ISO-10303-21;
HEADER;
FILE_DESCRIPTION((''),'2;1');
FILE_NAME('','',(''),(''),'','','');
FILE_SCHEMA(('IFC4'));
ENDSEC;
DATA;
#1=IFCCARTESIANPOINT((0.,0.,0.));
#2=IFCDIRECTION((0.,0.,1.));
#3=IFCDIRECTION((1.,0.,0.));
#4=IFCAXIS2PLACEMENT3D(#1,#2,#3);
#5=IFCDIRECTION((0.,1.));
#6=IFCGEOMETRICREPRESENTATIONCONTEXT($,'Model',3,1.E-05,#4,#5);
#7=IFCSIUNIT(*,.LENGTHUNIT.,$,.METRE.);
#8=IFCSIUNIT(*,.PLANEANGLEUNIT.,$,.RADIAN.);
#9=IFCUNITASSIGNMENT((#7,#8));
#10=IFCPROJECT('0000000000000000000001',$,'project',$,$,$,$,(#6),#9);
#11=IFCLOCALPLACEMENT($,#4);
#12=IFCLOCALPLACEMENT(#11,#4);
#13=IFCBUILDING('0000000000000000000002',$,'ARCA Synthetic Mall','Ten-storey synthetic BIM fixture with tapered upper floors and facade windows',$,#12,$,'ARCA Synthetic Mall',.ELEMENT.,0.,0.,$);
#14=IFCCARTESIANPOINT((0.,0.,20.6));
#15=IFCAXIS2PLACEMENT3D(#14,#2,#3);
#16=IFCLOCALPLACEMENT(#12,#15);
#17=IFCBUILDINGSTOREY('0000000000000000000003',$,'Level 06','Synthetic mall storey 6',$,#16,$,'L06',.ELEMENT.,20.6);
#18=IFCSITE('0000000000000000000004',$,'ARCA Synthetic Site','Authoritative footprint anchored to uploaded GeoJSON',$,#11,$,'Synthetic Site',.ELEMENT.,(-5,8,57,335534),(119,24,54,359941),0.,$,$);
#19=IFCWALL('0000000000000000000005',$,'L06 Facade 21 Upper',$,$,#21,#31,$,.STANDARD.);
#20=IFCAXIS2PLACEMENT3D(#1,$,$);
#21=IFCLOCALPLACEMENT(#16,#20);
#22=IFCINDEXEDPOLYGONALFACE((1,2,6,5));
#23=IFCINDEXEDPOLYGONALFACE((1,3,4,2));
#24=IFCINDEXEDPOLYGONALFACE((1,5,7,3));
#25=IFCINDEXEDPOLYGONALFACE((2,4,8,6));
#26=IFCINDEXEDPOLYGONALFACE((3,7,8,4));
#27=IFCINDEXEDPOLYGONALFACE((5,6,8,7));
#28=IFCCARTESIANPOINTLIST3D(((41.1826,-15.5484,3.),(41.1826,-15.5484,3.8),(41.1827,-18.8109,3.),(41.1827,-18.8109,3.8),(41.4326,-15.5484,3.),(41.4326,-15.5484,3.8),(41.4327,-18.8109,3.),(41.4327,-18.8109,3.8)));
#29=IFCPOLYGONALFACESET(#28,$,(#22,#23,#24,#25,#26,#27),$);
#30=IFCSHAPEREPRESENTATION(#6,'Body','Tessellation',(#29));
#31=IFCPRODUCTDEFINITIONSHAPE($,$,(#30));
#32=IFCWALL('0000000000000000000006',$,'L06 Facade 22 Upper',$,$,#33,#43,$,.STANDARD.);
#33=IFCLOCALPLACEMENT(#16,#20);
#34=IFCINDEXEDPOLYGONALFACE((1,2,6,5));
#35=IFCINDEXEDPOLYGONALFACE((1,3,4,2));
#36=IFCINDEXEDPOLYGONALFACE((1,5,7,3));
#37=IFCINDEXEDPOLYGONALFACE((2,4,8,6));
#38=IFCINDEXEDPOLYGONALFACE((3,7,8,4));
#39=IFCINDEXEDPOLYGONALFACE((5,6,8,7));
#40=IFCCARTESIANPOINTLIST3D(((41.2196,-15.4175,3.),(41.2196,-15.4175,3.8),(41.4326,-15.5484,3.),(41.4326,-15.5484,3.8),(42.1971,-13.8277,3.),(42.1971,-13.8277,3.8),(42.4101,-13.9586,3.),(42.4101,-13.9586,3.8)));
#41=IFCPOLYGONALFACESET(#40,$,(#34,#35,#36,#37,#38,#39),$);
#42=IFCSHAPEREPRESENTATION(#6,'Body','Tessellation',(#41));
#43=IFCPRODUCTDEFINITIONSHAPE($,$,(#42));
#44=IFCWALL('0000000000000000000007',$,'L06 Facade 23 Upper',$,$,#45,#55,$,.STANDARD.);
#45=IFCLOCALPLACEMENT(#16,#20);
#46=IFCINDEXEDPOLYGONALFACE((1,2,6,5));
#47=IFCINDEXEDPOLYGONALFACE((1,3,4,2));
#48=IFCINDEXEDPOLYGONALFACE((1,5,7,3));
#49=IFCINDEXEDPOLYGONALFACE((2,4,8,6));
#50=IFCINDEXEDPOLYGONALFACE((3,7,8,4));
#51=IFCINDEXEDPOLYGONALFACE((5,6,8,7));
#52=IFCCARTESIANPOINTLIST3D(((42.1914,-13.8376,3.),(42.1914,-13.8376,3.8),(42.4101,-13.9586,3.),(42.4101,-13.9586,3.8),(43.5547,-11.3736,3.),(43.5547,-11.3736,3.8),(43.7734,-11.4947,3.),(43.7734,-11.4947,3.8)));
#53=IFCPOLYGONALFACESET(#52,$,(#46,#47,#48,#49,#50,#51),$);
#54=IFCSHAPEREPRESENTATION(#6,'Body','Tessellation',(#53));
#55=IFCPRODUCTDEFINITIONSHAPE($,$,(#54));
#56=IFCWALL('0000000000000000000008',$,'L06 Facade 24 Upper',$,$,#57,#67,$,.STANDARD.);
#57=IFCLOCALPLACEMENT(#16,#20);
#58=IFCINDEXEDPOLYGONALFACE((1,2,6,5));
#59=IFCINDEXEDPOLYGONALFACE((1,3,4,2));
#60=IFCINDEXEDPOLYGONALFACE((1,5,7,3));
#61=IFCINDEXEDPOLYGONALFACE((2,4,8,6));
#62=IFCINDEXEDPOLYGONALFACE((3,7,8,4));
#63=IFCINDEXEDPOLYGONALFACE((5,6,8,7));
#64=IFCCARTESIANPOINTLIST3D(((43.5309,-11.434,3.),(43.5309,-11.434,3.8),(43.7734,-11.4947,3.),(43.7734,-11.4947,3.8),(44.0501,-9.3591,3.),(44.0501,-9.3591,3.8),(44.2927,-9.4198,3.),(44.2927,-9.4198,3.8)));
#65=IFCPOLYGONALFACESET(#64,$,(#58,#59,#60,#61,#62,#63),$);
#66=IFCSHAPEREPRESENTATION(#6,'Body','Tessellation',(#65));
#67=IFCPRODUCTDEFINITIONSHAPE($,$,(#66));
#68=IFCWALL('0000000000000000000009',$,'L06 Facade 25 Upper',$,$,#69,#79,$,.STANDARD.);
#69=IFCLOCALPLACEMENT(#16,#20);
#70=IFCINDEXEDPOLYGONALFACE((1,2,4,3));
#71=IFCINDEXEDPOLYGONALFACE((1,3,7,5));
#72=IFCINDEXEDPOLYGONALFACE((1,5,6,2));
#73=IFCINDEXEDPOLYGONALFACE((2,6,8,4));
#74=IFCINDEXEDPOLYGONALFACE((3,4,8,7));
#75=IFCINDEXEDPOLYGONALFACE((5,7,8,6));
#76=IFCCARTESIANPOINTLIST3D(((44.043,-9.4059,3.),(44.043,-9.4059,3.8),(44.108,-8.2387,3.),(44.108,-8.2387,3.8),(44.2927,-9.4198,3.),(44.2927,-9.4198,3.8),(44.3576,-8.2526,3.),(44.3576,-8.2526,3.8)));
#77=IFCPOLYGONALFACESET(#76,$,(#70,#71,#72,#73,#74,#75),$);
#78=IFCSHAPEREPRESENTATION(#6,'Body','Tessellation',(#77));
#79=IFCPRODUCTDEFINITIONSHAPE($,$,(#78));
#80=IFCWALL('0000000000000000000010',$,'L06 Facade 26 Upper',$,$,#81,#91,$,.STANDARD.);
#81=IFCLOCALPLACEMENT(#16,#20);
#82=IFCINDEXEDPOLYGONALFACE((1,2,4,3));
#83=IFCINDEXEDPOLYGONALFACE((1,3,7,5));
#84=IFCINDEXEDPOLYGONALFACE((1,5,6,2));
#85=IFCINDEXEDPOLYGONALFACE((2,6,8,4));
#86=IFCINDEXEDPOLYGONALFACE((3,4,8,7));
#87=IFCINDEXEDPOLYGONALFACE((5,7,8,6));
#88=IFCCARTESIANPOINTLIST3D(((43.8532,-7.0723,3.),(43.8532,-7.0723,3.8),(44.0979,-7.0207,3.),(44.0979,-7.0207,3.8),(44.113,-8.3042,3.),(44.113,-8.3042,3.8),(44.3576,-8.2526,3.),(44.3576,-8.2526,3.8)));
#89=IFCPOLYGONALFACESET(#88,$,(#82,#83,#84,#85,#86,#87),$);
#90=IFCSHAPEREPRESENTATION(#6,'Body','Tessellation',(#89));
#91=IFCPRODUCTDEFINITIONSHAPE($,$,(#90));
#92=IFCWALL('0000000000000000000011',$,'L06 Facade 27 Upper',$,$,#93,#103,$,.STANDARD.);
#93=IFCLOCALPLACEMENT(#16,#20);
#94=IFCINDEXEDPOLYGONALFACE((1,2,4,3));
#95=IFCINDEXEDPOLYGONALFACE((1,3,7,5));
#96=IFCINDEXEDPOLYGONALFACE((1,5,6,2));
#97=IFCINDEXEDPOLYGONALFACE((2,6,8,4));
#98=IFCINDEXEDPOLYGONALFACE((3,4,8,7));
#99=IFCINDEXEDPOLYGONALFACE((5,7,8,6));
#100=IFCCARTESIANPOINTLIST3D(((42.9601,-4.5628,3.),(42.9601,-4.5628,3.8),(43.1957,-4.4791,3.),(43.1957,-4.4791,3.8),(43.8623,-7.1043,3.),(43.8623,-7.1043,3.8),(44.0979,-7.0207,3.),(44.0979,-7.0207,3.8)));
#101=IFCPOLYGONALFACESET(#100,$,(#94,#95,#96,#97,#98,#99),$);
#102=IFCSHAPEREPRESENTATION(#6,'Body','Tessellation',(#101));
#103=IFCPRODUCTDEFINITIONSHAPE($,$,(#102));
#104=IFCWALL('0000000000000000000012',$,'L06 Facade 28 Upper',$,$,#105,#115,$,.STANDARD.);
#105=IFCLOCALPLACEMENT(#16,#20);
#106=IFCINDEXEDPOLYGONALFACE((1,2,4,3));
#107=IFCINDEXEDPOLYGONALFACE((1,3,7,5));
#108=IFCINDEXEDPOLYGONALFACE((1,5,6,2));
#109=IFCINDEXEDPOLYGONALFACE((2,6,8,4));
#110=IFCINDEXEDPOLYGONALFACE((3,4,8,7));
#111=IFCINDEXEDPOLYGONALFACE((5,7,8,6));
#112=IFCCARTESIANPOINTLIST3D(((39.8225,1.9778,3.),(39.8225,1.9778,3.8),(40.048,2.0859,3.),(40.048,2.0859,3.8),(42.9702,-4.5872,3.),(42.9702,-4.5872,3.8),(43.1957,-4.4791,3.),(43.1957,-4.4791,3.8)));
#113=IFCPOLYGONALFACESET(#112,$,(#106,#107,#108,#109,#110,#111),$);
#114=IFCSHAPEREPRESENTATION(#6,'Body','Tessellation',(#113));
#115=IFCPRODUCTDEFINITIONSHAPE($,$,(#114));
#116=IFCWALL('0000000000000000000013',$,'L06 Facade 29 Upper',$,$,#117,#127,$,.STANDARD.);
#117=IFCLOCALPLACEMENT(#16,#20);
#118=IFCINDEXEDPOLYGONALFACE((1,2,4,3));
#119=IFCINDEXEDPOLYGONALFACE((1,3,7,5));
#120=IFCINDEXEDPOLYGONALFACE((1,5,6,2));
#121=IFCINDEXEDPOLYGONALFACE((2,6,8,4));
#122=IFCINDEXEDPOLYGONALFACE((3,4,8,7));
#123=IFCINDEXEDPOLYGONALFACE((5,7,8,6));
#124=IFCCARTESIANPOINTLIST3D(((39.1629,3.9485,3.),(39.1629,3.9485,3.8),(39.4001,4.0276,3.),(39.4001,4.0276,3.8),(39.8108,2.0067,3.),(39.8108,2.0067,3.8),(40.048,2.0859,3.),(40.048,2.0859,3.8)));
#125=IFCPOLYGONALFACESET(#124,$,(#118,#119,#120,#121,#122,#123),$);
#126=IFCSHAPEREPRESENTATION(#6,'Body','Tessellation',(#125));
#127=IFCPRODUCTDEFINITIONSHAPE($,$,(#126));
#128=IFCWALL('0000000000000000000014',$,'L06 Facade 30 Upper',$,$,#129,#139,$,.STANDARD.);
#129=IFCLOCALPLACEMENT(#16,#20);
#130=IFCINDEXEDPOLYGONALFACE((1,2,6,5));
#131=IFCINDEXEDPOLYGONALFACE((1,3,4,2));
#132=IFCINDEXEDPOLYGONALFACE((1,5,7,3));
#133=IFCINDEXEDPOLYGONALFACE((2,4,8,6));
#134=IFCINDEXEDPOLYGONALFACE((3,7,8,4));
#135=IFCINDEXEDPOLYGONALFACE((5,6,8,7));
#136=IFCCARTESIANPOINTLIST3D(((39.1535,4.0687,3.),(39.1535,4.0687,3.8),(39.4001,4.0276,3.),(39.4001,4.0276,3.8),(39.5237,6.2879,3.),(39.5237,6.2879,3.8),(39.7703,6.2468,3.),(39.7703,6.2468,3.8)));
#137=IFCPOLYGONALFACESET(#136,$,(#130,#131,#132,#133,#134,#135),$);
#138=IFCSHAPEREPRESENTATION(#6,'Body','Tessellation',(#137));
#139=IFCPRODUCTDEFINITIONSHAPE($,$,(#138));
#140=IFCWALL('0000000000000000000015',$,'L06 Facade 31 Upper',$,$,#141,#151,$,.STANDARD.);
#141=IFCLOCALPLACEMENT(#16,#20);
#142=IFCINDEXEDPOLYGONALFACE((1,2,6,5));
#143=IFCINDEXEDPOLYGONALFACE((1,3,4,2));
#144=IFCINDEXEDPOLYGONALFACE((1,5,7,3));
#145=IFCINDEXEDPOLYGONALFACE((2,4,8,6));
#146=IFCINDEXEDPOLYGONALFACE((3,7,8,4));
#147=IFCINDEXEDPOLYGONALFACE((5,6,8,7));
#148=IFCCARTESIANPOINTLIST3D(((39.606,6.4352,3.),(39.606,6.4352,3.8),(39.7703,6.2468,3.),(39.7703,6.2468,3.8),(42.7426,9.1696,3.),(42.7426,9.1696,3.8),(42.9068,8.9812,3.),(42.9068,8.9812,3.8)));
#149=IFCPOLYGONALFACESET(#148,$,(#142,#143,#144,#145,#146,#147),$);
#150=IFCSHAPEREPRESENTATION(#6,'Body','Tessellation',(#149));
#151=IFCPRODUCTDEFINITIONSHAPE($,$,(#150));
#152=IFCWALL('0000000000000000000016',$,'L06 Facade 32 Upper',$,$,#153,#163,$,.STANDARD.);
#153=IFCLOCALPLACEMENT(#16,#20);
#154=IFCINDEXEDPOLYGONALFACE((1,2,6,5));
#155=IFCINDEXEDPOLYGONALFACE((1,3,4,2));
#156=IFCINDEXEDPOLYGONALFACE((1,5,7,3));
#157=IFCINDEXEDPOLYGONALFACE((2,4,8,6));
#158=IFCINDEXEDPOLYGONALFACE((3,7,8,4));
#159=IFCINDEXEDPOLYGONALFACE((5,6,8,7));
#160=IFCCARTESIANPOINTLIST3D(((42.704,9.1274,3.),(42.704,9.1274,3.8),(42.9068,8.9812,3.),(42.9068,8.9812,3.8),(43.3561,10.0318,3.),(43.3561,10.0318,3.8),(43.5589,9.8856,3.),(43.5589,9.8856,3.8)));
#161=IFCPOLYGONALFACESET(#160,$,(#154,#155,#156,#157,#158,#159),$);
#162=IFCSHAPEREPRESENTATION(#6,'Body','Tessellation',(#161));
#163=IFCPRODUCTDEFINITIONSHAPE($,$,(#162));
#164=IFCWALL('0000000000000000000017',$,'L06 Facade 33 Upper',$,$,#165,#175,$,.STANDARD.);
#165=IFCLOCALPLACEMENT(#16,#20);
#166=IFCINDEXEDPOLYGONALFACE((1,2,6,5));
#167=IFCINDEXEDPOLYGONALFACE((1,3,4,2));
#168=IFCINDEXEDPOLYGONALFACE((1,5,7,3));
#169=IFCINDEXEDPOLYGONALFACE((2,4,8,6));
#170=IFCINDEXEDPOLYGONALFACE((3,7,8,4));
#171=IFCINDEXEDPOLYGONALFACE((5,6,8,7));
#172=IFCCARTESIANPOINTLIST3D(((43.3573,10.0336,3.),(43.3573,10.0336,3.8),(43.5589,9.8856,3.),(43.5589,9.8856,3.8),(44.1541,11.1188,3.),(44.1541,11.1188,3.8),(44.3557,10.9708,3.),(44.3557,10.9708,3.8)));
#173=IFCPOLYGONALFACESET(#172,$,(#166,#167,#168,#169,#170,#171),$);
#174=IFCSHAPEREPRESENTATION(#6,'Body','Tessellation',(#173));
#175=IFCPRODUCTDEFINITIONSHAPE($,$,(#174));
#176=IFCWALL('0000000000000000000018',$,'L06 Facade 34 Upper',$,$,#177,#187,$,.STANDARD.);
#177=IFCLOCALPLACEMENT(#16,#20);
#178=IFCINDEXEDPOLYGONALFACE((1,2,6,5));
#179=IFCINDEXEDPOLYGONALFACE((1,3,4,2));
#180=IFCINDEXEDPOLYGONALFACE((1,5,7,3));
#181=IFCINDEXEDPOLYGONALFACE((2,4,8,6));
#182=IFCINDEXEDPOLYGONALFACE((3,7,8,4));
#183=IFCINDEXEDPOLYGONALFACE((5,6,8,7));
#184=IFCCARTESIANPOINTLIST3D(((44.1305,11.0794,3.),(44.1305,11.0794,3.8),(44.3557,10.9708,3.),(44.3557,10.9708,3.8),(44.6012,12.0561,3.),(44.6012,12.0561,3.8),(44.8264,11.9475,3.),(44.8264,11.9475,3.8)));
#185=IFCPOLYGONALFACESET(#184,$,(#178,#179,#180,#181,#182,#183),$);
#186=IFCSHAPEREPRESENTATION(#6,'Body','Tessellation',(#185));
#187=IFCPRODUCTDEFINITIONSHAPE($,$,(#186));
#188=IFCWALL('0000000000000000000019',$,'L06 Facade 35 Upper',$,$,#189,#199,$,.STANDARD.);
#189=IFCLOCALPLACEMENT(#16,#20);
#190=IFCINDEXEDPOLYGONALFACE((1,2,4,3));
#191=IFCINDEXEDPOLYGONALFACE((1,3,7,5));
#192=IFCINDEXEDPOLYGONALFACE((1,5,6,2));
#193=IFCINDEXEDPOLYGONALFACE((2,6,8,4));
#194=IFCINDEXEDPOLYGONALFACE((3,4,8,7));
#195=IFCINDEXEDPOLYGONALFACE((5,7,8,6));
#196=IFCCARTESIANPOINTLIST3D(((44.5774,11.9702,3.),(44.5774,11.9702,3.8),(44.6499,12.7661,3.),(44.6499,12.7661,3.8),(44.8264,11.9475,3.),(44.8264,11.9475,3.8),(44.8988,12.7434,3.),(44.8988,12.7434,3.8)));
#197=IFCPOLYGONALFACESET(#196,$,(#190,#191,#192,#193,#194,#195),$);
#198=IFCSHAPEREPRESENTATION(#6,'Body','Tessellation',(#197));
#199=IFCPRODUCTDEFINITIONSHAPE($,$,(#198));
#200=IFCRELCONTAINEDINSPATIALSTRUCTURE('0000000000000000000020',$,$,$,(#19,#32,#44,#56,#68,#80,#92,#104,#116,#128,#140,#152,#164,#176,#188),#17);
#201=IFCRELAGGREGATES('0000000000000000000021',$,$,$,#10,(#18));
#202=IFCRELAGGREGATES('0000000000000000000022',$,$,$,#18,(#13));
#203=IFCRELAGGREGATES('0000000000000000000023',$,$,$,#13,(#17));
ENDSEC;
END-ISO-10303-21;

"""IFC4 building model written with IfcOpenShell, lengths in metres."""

from ifc_helpers import new_model, si_unit, direction, frame, origin_with_axes, place, context, project, spatial, polyline, outline, extrude, element, save


model = new_model("IFC4")

# Units and contexts
model_context = context("Model", 3, precision=1e-05, world=origin_with_axes(), true_north=direction((0.0, 1.0)))
ifc_project = project(units=[si_unit("LENGTHUNIT", "METRE"), si_unit("PLANEANGLEUNIT", "RADIAN")], contexts=[model_context])

# Site, building, storey
site_placement = place(None, origin_with_axes())
site = spatial("IfcSite", under=ifc_project, at=site_placement, Name="ARCA Synthetic Site", Description="Authoritative footprint anchored to uploaded GeoJSON", LongName="Synthetic Site", CompositionType="ELEMENT", RefLatitude=(-5, 8, 57, 335534), RefLongitude=(119, 24, 54, 359941), RefElevation=0.0)
building_placement = place(site_placement, origin_with_axes())
building = spatial("IfcBuilding", under=site, at=building_placement, Name="ARCA Synthetic Mall", Description="Ten-storey synthetic BIM fixture with tapered upper floors and facade windows", LongName="ARCA Synthetic Mall", CompositionType="ELEMENT", ElevationOfRefHeight=0.0, ElevationOfTerrain=0.0)
storey_placement = place(building_placement, frame((0.0, 0.0, 20.6), z_axis=(0.0, 0.0, 1.0), x_axis=(1.0, 0.0, 0.0)))
storey = spatial("IfcBuildingStorey", under=building, at=storey_placement, Name="Level 06", Description="Synthetic mall storey 6", LongName="L06", CompositionType="ELEMENT", Elevation=20.6)

# Walls
wall_1_placement = place(storey_placement, frame((0.0, 0.0, 3.0), z_axis=(0.0, 0.0, 1.0), x_axis=(1.0, 0.0, 0.0)))
element("IfcWall", 1, at=wall_1_placement, inside=storey, Name="L06 Facade 21 Upper", PredefinedType="STANDARD", context=model_context, shape_type="SweptSolid", body=[
    extrude(outline(polyline([(41.4327, -18.8109), (41.4326, -15.5484), (41.1826, -15.5484), (41.1827, -18.8109), (41.4327, -18.8109)])), origin_with_axes(), (0.0, 0.0, 1.0), 0.8),
])
wall_2_placement = place(storey_placement, frame((0.0, 0.0, 3.0), z_axis=(0.0, 0.0, 1.0), x_axis=(1.0, 0.0, 0.0)))
element("IfcWall", 2, at=wall_2_placement, inside=storey, Name="L06 Facade 22 Upper", PredefinedType="STANDARD", context=model_context, shape_type="SweptSolid", body=[
    extrude(outline(polyline([(41.4326, -15.5484), (42.4101, -13.9586), (42.1971, -13.8277), (41.2196, -15.4175), (41.4326, -15.5484)])), origin_with_axes(), (0.0, 0.0, 1.0), 0.8),
])
wall_3_placement = place(storey_placement, frame((0.0, 0.0, 3.0), z_axis=(0.0, 0.0, 1.0), x_axis=(1.0, 0.0, 0.0)))
element("IfcWall", 3, at=wall_3_placement, inside=storey, Name="L06 Facade 23 Upper", PredefinedType="STANDARD", context=model_context, shape_type="SweptSolid", body=[
    extrude(outline(polyline([(42.4101, -13.9586), (43.7734, -11.4947), (43.5547, -11.3736), (42.1914, -13.8376), (42.4101, -13.9586)])), origin_with_axes(), (0.0, 0.0, 1.0), 0.8),
])
wall_4_placement = place(storey_placement, frame((0.0, 0.0, 3.0), z_axis=(0.0, 0.0, 1.0), x_axis=(1.0, 0.0, 0.0)))
element("IfcWall", 4, at=wall_4_placement, inside=storey, Name="L06 Facade 24 Upper", PredefinedType="STANDARD", context=model_context, shape_type="SweptSolid", body=[
    extrude(outline(polyline([(43.7734, -11.4947), (44.2927, -9.4198), (44.0501, -9.3591), (43.5309, -11.434), (43.7734, -11.4947)])), origin_with_axes(), (0.0, 0.0, 1.0), 0.8),
])
wall_5_placement = place(storey_placement, frame((0.0, 0.0, 3.0), z_axis=(0.0, 0.0, 1.0), x_axis=(1.0, 0.0, 0.0)))
element("IfcWall", 5, at=wall_5_placement, inside=storey, Name="L06 Facade 25 Upper", PredefinedType="STANDARD", context=model_context, shape_type="SweptSolid", body=[
    extrude(outline(polyline([(44.2927, -9.4198), (44.3576, -8.2526), (44.108, -8.2387), (44.043, -9.4059), (44.2927, -9.4198)])), origin_with_axes(), (0.0, 0.0, 1.0), 0.8),
])
wall_6_placement = place(storey_placement, frame((0.0, 0.0, 3.0), z_axis=(0.0, 0.0, 1.0), x_axis=(1.0, 0.0, 0.0)))
element("IfcWall", 6, at=wall_6_placement, inside=storey, Name="L06 Facade 26 Upper", PredefinedType="STANDARD", context=model_context, shape_type="SweptSolid", body=[
    extrude(outline(polyline([(44.3576, -8.2526), (44.0979, -7.0207), (43.8532, -7.0723), (44.113, -8.3042), (44.3576, -8.2526)])), origin_with_axes(), (0.0, 0.0, 1.0), 0.8),
])
wall_7_placement = place(storey_placement, frame((0.0, 0.0, 3.0), z_axis=(0.0, 0.0, 1.0), x_axis=(1.0, 0.0, 0.0)))
element("IfcWall", 7, at=wall_7_placement, inside=storey, Name="L06 Facade 27 Upper", PredefinedType="STANDARD", context=model_context, shape_type="SweptSolid", body=[
    extrude(outline(polyline([(44.0979, -7.0207), (43.1957, -4.4791), (42.9601, -4.5628), (43.8623, -7.1043), (44.0979, -7.0207)])), origin_with_axes(), (0.0, 0.0, 1.0), 0.8),
])
wall_8_placement = place(storey_placement, frame((0.0, 0.0, 3.0), z_axis=(0.0, 0.0, 1.0), x_axis=(1.0, 0.0, 0.0)))
element("IfcWall", 8, at=wall_8_placement, inside=storey, Name="L06 Facade 28 Upper", PredefinedType="STANDARD", context=model_context, shape_type="SweptSolid", body=[
    extrude(outline(polyline([(43.1957, -4.4791), (40.048, 2.0859), (39.8225, 1.9778), (42.9702, -4.5872), (43.1957, -4.4791)])), origin_with_axes(), (0.0, 0.0, 1.0), 0.8),
])
wall_9_placement = place(storey_placement, frame((0.0, 0.0, 3.0), z_axis=(0.0, 0.0, 1.0), x_axis=(1.0, 0.0, 0.0)))
element("IfcWall", 9, at=wall_9_placement, inside=storey, Name="L06 Facade 29 Upper", PredefinedType="STANDARD", context=model_context, shape_type="SweptSolid", body=[
    extrude(outline(polyline([(40.048, 2.0859), (39.4001, 4.0276), (39.1629, 3.9485), (39.8108, 2.0067), (40.048, 2.0859)])), origin_with_axes(), (0.0, 0.0, 1.0), 0.8),
])
wall_10_placement = place(storey_placement, frame((0.0, 0.0, 3.0), z_axis=(0.0, 0.0, 1.0), x_axis=(1.0, 0.0, 0.0)))
element("IfcWall", 10, at=wall_10_placement, inside=storey, Name="L06 Facade 30 Upper", PredefinedType="STANDARD", context=model_context, shape_type="SweptSolid", body=[
    extrude(outline(polyline([(39.4001, 4.0276), (39.7703, 6.2468), (39.5237, 6.2879), (39.1535, 4.0687), (39.4001, 4.0276)])), origin_with_axes(), (0.0, 0.0, 1.0), 0.8),
])
wall_11_placement = place(storey_placement, frame((0.0, 0.0, 3.0), z_axis=(0.0, 0.0, 1.0), x_axis=(1.0, 0.0, 0.0)))
element("IfcWall", 11, at=wall_11_placement, inside=storey, Name="L06 Facade 31 Upper", PredefinedType="STANDARD", context=model_context, shape_type="SweptSolid", body=[
    extrude(outline(polyline([(39.7703, 6.2468), (42.9068, 8.9812), (42.7426, 9.1696), (39.606, 6.4352), (39.7703, 6.2468)])), origin_with_axes(), (0.0, 0.0, 1.0), 0.8),
])
wall_12_placement = place(storey_placement, frame((0.0, 0.0, 3.0), z_axis=(0.0, 0.0, 1.0), x_axis=(1.0, 0.0, 0.0)))
element("IfcWall", 12, at=wall_12_placement, inside=storey, Name="L06 Facade 32 Upper", PredefinedType="STANDARD", context=model_context, shape_type="SweptSolid", body=[
    extrude(outline(polyline([(42.9068, 8.9812), (43.5589, 9.8856), (43.3561, 10.0318), (42.704, 9.1274), (42.9068, 8.9812)])), origin_with_axes(), (0.0, 0.0, 1.0), 0.8),
])
wall_13_placement = place(storey_placement, frame((0.0, 0.0, 3.0), z_axis=(0.0, 0.0, 1.0), x_axis=(1.0, 0.0, 0.0)))
element("IfcWall", 13, at=wall_13_placement, inside=storey, Name="L06 Facade 33 Upper", PredefinedType="STANDARD", context=model_context, shape_type="SweptSolid", body=[
    extrude(outline(polyline([(43.5589, 9.8856), (44.3557, 10.9708), (44.1541, 11.1188), (43.3573, 10.0336), (43.5589, 9.8856)])), origin_with_axes(), (0.0, 0.0, 1.0), 0.8),
])
wall_14_placement = place(storey_placement, frame((0.0, 0.0, 3.0), z_axis=(0.0, 0.0, 1.0), x_axis=(1.0, 0.0, 0.0)))
element("IfcWall", 14, at=wall_14_placement, inside=storey, Name="L06 Facade 34 Upper", PredefinedType="STANDARD", context=model_context, shape_type="SweptSolid", body=[
    extrude(outline(polyline([(44.3557, 10.9708), (44.8264, 11.9475), (44.6012, 12.0561), (44.1305, 11.0794), (44.3557, 10.9708)])), origin_with_axes(), (0.0, 0.0, 1.0), 0.8),
])
wall_15_placement = place(storey_placement, frame((0.0, 0.0, 3.0), z_axis=(0.0, 0.0, 1.0), x_axis=(1.0, 0.0, 0.0)))
element("IfcWall", 15, at=wall_15_placement, inside=storey, Name="L06 Facade 35 Upper", PredefinedType="STANDARD", context=model_context, shape_type="SweptSolid", body=[
    extrude(outline(polyline([(44.8264, 11.9475), (44.8988, 12.7434), (44.6499, 12.7661), (44.5774, 11.9702), (44.8264, 11.9475)])), origin_with_axes(), (0.0, 0.0, 1.0), 0.8),
])

save(model, "model.ifc")
